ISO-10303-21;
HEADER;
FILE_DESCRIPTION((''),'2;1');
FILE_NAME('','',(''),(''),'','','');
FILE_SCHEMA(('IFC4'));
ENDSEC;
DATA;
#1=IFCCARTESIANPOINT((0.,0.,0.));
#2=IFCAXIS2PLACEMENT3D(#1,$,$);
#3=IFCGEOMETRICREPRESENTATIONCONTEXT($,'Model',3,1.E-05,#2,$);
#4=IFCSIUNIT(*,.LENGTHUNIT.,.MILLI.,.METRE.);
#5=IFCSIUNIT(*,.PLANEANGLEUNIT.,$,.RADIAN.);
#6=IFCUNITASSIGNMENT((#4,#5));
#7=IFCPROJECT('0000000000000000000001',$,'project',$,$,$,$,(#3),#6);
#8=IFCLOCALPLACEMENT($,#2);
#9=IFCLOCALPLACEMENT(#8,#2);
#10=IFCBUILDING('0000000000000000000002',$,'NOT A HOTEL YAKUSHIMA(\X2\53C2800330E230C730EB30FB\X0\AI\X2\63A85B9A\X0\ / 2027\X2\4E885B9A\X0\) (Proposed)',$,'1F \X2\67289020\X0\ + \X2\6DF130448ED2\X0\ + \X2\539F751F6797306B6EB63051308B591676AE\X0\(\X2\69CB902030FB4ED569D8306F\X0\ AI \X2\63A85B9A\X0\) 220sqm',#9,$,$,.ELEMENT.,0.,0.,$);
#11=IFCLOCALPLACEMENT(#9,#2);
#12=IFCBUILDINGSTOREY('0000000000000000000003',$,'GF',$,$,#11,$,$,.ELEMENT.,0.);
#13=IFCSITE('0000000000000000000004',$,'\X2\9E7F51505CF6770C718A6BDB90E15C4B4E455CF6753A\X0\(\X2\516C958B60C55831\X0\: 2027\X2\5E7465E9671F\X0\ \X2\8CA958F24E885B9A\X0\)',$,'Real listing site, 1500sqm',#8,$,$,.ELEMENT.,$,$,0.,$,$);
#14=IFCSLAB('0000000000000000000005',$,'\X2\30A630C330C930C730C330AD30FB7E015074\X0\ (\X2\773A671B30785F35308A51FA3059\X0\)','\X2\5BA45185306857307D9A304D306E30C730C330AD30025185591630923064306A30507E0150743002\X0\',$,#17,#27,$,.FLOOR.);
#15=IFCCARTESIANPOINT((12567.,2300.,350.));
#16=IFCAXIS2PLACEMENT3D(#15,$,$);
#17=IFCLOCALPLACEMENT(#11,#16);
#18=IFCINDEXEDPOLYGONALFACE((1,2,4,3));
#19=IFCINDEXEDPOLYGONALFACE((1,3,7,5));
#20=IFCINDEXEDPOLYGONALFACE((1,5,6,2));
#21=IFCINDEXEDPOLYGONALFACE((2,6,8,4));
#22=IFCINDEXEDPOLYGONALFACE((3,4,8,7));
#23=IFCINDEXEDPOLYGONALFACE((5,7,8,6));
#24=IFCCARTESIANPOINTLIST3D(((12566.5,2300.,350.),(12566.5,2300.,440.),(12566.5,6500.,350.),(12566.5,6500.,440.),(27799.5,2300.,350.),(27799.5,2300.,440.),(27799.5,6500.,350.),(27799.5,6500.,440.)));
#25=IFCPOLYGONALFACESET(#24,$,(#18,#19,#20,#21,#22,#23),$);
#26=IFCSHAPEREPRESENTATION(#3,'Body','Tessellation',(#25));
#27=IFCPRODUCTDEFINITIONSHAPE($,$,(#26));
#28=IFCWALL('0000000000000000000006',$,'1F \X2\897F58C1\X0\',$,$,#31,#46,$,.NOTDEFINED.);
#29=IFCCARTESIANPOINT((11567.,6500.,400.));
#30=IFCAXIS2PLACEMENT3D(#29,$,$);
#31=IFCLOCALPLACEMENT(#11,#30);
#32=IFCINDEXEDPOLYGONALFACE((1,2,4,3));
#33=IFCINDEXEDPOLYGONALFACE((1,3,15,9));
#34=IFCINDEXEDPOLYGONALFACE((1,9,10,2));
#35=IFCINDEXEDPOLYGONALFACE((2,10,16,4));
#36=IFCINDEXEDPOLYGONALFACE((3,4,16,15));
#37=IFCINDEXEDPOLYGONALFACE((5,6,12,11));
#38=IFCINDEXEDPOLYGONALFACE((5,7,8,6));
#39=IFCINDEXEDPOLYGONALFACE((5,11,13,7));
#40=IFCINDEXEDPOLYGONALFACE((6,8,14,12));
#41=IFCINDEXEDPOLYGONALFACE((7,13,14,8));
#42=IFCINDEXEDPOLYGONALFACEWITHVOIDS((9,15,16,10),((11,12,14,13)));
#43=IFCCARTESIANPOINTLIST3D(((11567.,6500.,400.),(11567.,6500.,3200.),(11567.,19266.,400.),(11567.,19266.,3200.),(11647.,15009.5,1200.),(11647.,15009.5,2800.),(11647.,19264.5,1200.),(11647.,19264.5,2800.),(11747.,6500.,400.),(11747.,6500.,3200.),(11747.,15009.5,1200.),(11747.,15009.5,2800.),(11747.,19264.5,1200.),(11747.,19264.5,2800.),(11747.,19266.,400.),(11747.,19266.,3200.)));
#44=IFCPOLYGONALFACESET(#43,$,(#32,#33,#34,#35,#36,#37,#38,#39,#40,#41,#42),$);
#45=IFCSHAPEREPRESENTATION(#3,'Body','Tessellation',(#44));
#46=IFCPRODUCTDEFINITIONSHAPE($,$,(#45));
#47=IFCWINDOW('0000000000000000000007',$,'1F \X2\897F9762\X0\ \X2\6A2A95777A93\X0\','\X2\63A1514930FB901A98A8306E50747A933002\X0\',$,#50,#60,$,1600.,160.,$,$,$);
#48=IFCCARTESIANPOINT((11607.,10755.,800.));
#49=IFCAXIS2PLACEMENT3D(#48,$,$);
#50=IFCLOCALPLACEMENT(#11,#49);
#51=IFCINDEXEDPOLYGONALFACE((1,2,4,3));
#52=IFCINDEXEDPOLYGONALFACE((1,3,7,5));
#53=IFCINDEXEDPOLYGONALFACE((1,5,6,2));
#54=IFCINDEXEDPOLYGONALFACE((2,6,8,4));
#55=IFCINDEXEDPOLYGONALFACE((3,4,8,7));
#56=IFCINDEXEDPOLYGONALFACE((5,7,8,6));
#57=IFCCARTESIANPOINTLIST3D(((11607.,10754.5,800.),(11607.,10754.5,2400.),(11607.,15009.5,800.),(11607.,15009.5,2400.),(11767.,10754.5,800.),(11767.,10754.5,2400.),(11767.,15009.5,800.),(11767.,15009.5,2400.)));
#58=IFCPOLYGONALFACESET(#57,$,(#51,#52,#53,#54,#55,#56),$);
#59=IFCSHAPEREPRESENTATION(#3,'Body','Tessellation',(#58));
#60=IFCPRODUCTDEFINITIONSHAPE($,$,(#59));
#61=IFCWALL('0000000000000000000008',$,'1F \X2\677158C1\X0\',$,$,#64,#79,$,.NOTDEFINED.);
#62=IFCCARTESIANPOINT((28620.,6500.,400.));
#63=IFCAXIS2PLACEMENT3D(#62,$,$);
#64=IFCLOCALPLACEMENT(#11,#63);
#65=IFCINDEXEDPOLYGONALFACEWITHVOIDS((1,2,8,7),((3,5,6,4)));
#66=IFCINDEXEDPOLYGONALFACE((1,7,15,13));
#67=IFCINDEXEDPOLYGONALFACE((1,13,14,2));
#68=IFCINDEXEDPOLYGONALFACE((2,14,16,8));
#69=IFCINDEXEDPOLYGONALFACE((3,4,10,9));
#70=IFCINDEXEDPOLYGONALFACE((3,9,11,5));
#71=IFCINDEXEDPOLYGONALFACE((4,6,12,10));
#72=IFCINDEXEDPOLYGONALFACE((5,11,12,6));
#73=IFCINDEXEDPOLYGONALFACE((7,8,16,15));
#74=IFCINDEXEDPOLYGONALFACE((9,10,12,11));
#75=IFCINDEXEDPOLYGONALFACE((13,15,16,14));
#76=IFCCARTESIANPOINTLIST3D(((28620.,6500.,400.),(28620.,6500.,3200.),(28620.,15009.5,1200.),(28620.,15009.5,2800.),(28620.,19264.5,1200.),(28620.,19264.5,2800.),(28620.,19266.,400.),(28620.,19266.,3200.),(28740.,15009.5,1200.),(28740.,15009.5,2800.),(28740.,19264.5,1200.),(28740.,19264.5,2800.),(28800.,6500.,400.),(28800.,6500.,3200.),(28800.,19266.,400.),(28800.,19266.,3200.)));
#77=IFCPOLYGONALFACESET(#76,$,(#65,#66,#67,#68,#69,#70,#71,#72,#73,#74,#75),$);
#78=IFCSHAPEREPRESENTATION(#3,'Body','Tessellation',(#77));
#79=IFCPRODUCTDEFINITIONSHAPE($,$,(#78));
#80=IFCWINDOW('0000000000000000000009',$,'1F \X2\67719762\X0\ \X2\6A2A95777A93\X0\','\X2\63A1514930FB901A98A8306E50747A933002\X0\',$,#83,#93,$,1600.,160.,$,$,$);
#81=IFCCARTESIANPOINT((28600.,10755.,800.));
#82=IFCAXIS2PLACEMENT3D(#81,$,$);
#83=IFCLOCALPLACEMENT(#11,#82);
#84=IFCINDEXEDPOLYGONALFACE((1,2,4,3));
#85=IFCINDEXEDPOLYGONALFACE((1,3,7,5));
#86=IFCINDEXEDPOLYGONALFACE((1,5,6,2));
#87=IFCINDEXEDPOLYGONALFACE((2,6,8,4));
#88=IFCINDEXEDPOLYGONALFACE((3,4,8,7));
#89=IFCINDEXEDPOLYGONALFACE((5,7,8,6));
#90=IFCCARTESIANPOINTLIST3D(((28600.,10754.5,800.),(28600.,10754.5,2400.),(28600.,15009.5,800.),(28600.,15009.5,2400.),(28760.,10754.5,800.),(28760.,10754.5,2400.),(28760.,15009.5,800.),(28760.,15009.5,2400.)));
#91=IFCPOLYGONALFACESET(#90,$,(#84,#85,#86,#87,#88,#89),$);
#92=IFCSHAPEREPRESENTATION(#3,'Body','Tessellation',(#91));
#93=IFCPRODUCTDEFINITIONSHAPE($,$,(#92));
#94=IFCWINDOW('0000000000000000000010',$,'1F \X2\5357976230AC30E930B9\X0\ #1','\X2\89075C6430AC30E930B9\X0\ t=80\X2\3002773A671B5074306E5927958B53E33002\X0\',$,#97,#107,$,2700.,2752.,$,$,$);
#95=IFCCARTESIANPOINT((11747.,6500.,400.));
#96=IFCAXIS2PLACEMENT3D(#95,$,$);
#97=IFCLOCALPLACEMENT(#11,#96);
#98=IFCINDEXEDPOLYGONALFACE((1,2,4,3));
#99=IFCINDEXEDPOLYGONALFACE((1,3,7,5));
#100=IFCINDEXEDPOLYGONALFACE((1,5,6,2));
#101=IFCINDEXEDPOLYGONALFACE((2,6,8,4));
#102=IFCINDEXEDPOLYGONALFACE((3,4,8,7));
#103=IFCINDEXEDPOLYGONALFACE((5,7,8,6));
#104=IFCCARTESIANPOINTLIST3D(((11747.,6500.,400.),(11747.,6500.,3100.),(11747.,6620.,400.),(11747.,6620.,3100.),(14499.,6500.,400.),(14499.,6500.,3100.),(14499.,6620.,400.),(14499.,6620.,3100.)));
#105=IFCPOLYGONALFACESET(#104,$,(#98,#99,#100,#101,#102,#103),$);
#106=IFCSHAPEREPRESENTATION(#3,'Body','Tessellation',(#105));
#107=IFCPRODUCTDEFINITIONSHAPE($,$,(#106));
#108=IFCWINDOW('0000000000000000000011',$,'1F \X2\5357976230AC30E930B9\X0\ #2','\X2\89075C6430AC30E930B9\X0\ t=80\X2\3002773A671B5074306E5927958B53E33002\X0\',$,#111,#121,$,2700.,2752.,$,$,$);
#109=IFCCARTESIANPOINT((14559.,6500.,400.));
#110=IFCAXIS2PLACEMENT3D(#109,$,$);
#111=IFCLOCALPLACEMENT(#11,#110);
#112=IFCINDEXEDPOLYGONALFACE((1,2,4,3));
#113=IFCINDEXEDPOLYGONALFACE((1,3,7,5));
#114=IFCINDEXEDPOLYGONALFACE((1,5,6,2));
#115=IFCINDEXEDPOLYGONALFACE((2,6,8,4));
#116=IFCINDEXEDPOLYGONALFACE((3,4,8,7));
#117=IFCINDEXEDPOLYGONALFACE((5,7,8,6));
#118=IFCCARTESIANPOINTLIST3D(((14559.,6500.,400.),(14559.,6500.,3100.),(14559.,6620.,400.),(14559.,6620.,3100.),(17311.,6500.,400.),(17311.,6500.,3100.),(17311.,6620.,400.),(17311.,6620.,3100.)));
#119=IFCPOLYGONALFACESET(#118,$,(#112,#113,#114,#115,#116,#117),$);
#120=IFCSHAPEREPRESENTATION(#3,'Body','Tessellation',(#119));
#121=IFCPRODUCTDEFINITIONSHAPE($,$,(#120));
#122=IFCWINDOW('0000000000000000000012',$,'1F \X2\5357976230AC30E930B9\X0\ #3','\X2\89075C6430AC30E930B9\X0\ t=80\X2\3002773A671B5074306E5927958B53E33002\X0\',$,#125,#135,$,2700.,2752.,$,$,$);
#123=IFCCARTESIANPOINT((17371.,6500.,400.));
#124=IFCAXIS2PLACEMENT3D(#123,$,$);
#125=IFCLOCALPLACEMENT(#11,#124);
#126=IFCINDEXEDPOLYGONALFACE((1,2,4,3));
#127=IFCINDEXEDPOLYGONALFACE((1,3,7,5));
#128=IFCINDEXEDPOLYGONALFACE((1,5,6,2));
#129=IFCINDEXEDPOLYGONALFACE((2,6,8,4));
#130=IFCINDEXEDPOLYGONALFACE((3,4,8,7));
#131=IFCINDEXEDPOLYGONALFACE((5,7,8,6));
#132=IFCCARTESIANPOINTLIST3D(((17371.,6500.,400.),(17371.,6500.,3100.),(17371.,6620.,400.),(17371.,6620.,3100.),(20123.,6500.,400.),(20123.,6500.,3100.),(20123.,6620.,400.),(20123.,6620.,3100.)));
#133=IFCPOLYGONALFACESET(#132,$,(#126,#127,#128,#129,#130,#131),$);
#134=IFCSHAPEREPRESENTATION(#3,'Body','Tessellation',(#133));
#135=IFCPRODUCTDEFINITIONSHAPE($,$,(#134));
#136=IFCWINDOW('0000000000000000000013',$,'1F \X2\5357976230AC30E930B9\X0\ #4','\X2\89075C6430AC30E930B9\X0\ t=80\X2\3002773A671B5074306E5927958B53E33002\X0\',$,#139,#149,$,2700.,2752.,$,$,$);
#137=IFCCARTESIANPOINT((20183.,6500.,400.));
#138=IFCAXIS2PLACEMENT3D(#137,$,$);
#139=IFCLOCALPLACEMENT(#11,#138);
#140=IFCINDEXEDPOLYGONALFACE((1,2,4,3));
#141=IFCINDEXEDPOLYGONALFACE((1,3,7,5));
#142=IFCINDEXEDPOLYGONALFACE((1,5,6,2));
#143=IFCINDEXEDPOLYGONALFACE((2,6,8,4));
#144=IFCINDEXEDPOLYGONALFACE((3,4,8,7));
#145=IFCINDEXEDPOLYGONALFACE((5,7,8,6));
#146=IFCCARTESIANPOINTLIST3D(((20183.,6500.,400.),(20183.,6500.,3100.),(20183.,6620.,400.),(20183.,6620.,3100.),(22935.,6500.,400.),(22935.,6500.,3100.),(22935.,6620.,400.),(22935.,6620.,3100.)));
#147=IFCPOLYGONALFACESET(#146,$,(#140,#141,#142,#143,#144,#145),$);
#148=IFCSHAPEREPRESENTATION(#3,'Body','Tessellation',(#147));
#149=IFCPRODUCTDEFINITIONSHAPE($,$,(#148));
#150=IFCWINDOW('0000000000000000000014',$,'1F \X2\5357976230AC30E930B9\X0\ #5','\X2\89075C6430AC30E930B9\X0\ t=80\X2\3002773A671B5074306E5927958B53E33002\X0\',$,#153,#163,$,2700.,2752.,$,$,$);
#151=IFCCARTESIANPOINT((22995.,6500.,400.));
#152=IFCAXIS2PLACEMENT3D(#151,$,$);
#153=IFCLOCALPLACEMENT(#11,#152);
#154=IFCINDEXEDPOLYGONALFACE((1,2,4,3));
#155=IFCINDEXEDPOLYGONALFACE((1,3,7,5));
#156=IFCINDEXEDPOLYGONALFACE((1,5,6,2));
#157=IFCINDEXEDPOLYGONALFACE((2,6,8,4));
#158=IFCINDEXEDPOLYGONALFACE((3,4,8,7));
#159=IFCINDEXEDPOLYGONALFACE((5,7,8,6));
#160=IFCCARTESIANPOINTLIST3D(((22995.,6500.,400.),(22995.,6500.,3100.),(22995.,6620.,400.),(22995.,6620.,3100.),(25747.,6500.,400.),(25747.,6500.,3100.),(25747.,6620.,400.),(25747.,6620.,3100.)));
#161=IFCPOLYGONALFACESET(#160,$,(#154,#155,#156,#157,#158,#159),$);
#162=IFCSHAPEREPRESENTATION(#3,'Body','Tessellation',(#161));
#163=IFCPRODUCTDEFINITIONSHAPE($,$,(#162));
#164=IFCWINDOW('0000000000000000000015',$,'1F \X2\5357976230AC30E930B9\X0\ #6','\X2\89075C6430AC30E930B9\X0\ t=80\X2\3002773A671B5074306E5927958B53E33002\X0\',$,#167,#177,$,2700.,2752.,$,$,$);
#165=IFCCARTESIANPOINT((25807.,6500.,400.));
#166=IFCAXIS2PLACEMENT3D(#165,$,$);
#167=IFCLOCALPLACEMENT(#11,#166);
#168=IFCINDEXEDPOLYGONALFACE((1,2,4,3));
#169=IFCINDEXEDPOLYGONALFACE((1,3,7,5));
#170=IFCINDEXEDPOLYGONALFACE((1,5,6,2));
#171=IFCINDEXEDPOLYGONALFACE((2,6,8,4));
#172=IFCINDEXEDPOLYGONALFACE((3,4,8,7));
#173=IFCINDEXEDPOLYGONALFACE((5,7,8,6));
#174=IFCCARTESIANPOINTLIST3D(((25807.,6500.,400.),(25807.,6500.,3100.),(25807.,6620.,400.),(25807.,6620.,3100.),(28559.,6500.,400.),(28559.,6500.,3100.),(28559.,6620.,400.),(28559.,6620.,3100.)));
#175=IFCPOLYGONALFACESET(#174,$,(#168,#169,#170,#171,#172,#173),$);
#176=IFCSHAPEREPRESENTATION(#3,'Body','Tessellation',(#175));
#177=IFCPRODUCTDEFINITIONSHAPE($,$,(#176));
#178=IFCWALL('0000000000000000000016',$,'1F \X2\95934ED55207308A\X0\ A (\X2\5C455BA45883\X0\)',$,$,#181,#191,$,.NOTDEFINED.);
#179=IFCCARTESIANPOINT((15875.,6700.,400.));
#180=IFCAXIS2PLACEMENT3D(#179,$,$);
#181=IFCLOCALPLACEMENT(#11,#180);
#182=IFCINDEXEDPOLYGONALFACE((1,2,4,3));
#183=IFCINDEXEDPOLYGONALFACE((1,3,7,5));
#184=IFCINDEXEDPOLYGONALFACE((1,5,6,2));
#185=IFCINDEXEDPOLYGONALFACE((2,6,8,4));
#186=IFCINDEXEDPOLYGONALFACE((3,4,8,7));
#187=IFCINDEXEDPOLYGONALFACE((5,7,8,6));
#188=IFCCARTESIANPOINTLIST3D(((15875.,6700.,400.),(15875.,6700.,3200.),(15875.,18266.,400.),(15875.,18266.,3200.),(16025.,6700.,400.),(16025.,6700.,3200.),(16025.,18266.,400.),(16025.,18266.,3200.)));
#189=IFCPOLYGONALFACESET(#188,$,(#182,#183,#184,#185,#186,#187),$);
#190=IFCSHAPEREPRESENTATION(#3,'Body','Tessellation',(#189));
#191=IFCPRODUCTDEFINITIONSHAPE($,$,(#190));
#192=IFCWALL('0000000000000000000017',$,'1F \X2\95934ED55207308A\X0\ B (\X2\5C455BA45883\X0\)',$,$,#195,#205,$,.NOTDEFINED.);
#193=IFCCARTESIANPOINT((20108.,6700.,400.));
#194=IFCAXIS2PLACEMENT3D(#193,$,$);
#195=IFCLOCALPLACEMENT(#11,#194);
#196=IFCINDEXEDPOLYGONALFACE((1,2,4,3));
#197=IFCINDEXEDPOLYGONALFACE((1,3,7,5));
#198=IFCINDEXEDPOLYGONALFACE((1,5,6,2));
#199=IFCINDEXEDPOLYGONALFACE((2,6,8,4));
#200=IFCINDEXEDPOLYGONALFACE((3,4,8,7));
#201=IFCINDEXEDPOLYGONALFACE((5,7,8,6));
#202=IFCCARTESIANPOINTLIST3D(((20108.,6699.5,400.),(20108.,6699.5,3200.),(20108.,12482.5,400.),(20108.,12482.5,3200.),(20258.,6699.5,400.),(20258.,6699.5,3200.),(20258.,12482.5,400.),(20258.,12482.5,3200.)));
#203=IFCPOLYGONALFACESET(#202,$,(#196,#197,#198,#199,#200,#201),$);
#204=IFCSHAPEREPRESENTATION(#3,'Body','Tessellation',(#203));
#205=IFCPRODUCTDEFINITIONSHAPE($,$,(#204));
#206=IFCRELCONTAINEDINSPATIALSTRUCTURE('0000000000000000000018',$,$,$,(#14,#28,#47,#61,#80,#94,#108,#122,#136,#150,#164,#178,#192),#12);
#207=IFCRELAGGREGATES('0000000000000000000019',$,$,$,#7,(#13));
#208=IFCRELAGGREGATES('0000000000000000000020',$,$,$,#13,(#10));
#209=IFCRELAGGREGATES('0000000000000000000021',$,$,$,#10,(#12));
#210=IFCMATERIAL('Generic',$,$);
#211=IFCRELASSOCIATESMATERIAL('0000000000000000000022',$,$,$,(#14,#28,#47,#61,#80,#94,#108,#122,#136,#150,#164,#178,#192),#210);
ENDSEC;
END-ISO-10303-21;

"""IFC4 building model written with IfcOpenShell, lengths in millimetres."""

from ifc_helpers import new_model, si_unit, frame, frame_2d, origin, place, context, project, spatial, rectangle, extrude, material, element, fill, save


model = new_model("IFC4")

# Units and contexts
model_context = context("Model", 3, precision=1e-05, world=origin())
ifc_project = project(units=[si_unit("LENGTHUNIT", "METRE", prefix="MILLI"), si_unit("PLANEANGLEUNIT", "RADIAN")], contexts=[model_context])

# Site, building, storey
site_placement = place(None, origin())
site = spatial("IfcSite", under=ifc_project, at=site_placement, Name="鹿児島県熊毛郡屋久島町(公開情報: 2027年早期 販売予定)", ObjectType="Real listing site, 1500sqm", CompositionType="ELEMENT", RefElevation=0.0)
building_placement = place(site_placement, origin())
building = spatial("IfcBuilding", under=site, at=building_placement, Name="NOT A HOTEL YAKUSHIMA(参考モデル・AI推定 / 2027予定) (Proposed)", ObjectType="1F 木造 + 深い軒 + 原生林に溶ける外皮(構造・仕様は AI 推定) 220sqm", CompositionType="ELEMENT", ElevationOfRefHeight=0.0, ElevationOfTerrain=0.0)
storey_placement = place(building_placement, origin())
storey = spatial("IfcBuildingStorey", under=building, at=storey_placement, Name="GF", CompositionType="ELEMENT", Elevation=0.0)

# Slab
ifc_material_1 = material(Name="Generic")
slab_1_placement = place(storey_placement, frame((12567.0, 2300.0, 350.0)))
element("IfcSlab", 1, at=slab_1_placement, inside=storey, material=ifc_material_1, Name="ウッドデッキ・縁側 (眺望へ張り出す)", Description="室内と地続きのデッキ。内外をつなぐ縁側。", PredefinedType="FLOOR", context=model_context, shape_type="SweptSolid", body=[
    extrude(rectangle(XDim=15233.0, YDim=4200.0, at=frame_2d((7616.0, 2100.0))), frame((12567.0, 2300.0, 350.0)), (0.0, 0.0, 1.0), 90.0),
])

# Walls, openings, windows
wall_1_placement = place(storey_placement, frame((11567.0, 6500.0, 400.0)))
wall_1 = element("IfcWall", 2, at=wall_1_placement, inside=storey, material=ifc_material_1, Name="1F 西壁", PredefinedType="NOTDEFINED", context=model_context, shape_type="SweptSolid", body=[
    extrude(rectangle(XDim=180.0, YDim=12766.0, at=frame_2d((90.0, 6383.0))), frame((11567.0, 6500.0, 400.0)), (0.0, 0.0, 1.0), 2800.0),
])
opening_1_placement = place(storey_placement, frame((11607.0, 10755.0, 800.0)))
opening_1 = element("IfcOpeningElement", 3, at=opening_1_placement, cuts=wall_1, PredefinedType="NOTDEFINED", context=model_context, shape_type="SweptSolid", body=[
    extrude(rectangle(XDim=160.0, YDim=4255.0, at=frame_2d((80.0, 2127.0))), frame((11607.0, 10755.0, 800.0)), (0.0, 0.0, 1.0), 1600.0),
])
window_1_placement = place(storey_placement, frame((11607.0, 10755.0, 800.0)))
window_1 = element("IfcWindow", 4, at=window_1_placement, inside=storey, material=ifc_material_1, Name="1F 西面 横長窓", Description="採光・通風の側窓。", OverallHeight=1600.0, OverallWidth=160.0, context=model_context, shape_type="SweptSolid", body=[
    extrude(rectangle(XDim=160.0, YDim=4255.0, at=frame_2d((80.0, 2127.0))), frame((11607.0, 10755.0, 800.0)), (0.0, 0.0, 1.0), 1600.0),
])
fill(opening_1, window_1)
wall_2_placement = place(storey_placement, frame((28620.0, 6500.0, 400.0)))
wall_2 = element("IfcWall", 5, at=wall_2_placement, inside=storey, material=ifc_material_1, Name="1F 東壁", PredefinedType="NOTDEFINED", context=model_context, shape_type="SweptSolid", body=[
    extrude(rectangle(XDim=180.0, YDim=12766.0, at=frame_2d((90.0, 6383.0))), frame((28620.0, 6500.0, 400.0)), (0.0, 0.0, 1.0), 2800.0),
])
opening_2_placement = place(storey_placement, frame((28600.0, 10755.0, 800.0)))
opening_2 = element("IfcOpeningElement", 6, at=opening_2_placement, cuts=wall_2, PredefinedType="NOTDEFINED", context=model_context, shape_type="SweptSolid", body=[
    extrude(rectangle(XDim=160.0, YDim=4255.0, at=frame_2d((80.0, 2127.0))), frame((28600.0, 10755.0, 800.0)), (0.0, 0.0, 1.0), 1600.0),
])
window_2_placement = place(storey_placement, frame((28600.0, 10755.0, 800.0)))
window_2 = element("IfcWindow", 7, at=window_2_placement, inside=storey, material=ifc_material_1, Name="1F 東面 横長窓", Description="採光・通風の側窓。", OverallHeight=1600.0, OverallWidth=160.0, context=model_context, shape_type="SweptSolid", body=[
    extrude(rectangle(XDim=160.0, YDim=4255.0, at=frame_2d((80.0, 2127.0))), frame((28600.0, 10755.0, 800.0)), (0.0, 0.0, 1.0), 1600.0),
])
fill(opening_2, window_2)

# Windows
window_3_placement = place(storey_placement, frame((11747.0, 6500.0, 400.0)))
element("IfcWindow", 8, at=window_3_placement, inside=storey, material=ifc_material_1, Name="1F 南面ガラス #1", Description="複層ガラス t=80。眺望側の大開口。", OverallHeight=2700.0, OverallWidth=2752.0, context=model_context, shape_type="SweptSolid", body=[
    extrude(rectangle(XDim=2752.0, YDim=120.0, at=frame_2d((1376.0, 60.0))), frame((11747.0, 6500.0, 400.0)), (0.0, 0.0, 1.0), 2700.0),
])
window_4_placement = place(storey_placement, frame((14559.0, 6500.0, 400.0)))
element("IfcWindow", 9, at=window_4_placement, inside=storey, material=ifc_material_1, Name="1F 南面ガラス #2", Description="複層ガラス t=80。眺望側の大開口。", OverallHeight=2700.0, OverallWidth=2752.0, context=model_context, shape_type="SweptSolid", body=[
    extrude(rectangle(XDim=2752.0, YDim=120.0, at=frame_2d((1376.0, 60.0))), frame((14559.0, 6500.0, 400.0)), (0.0, 0.0, 1.0), 2700.0),
])
window_5_placement = place(storey_placement, frame((17371.0, 6500.0, 400.0)))
element("IfcWindow", 10, at=window_5_placement, inside=storey, material=ifc_material_1, Name="1F 南面ガラス #3", Description="複層ガラス t=80。眺望側の大開口。", OverallHeight=2700.0, OverallWidth=2752.0, context=model_context, shape_type="SweptSolid", body=[
    extrude(rectangle(XDim=2752.0, YDim=120.0, at=frame_2d((1376.0, 60.0))), frame((17371.0, 6500.0, 400.0)), (0.0, 0.0, 1.0), 2700.0),
])
window_6_placement = place(storey_placement, frame((20183.0, 6500.0, 400.0)))
element("IfcWindow", 11, at=window_6_placement, inside=storey, material=ifc_material_1, Name="1F 南面ガラス #4", Description="複層ガラス t=80。眺望側の大開口。", OverallHeight=2700.0, OverallWidth=2752.0, context=model_context, shape_type="SweptSolid", body=[
    extrude(rectangle(XDim=2752.0, YDim=120.0, at=frame_2d((1376.0, 60.0))), frame((20183.0, 6500.0, 400.0)), (0.0, 0.0, 1.0), 2700.0),
])
window_7_placement = place(storey_placement, frame((22995.0, 6500.0, 400.0)))
element("IfcWindow", 12, at=window_7_placement, inside=storey, material=ifc_material_1, Name="1F 南面ガラス #5", Description="複層ガラス t=80。眺望側の大開口。", OverallHeight=2700.0, OverallWidth=2752.0, context=model_context, shape_type="SweptSolid", body=[
    extrude(rectangle(XDim=2752.0, YDim=120.0, at=frame_2d((1376.0, 60.0))), frame((22995.0, 6500.0, 400.0)), (0.0, 0.0, 1.0), 2700.0),
])
window_8_placement = place(storey_placement, frame((25807.0, 6500.0, 400.0)))
element("IfcWindow", 13, at=window_8_placement, inside=storey, material=ifc_material_1, Name="1F 南面ガラス #6", Description="複層ガラス t=80。眺望側の大開口。", OverallHeight=2700.0, OverallWidth=2752.0, context=model_context, shape_type="SweptSolid", body=[
    extrude(rectangle(XDim=2752.0, YDim=120.0, at=frame_2d((1376.0, 60.0))), frame((25807.0, 6500.0, 400.0)), (0.0, 0.0, 1.0), 2700.0),
])

# Walls
wall_3_placement = place(storey_placement, frame((15875.0, 6700.0, 400.0)))
element("IfcWall", 14, at=wall_3_placement, inside=storey, material=ifc_material_1, Name="1F 間仕切り A (居室境)", PredefinedType="NOTDEFINED", context=model_context, shape_type="SweptSolid", body=[
    extrude(rectangle(XDim=150.0, YDim=11566.0, at=frame_2d((75.0, 5783.0))), frame((15875.0, 6700.0, 400.0)), (0.0, 0.0, 1.0), 2800.0),
])
wall_4_placement = place(storey_placement, frame((20108.0, 6700.0, 400.0)))
element("IfcWall", 15, at=wall_4_placement, inside=storey, material=ifc_material_1, Name="1F 間仕切り B (居室境)", PredefinedType="NOTDEFINED", context=model_context, shape_type="SweptSolid", body=[
    extrude(rectangle(XDim=150.0, YDim=5783.0, at=frame_2d((75.0, 2891.0))), frame((20108.0, 6700.0, 400.0)), (0.0, 0.0, 1.0), 2800.0),
])

save(model, "model.ifc")
